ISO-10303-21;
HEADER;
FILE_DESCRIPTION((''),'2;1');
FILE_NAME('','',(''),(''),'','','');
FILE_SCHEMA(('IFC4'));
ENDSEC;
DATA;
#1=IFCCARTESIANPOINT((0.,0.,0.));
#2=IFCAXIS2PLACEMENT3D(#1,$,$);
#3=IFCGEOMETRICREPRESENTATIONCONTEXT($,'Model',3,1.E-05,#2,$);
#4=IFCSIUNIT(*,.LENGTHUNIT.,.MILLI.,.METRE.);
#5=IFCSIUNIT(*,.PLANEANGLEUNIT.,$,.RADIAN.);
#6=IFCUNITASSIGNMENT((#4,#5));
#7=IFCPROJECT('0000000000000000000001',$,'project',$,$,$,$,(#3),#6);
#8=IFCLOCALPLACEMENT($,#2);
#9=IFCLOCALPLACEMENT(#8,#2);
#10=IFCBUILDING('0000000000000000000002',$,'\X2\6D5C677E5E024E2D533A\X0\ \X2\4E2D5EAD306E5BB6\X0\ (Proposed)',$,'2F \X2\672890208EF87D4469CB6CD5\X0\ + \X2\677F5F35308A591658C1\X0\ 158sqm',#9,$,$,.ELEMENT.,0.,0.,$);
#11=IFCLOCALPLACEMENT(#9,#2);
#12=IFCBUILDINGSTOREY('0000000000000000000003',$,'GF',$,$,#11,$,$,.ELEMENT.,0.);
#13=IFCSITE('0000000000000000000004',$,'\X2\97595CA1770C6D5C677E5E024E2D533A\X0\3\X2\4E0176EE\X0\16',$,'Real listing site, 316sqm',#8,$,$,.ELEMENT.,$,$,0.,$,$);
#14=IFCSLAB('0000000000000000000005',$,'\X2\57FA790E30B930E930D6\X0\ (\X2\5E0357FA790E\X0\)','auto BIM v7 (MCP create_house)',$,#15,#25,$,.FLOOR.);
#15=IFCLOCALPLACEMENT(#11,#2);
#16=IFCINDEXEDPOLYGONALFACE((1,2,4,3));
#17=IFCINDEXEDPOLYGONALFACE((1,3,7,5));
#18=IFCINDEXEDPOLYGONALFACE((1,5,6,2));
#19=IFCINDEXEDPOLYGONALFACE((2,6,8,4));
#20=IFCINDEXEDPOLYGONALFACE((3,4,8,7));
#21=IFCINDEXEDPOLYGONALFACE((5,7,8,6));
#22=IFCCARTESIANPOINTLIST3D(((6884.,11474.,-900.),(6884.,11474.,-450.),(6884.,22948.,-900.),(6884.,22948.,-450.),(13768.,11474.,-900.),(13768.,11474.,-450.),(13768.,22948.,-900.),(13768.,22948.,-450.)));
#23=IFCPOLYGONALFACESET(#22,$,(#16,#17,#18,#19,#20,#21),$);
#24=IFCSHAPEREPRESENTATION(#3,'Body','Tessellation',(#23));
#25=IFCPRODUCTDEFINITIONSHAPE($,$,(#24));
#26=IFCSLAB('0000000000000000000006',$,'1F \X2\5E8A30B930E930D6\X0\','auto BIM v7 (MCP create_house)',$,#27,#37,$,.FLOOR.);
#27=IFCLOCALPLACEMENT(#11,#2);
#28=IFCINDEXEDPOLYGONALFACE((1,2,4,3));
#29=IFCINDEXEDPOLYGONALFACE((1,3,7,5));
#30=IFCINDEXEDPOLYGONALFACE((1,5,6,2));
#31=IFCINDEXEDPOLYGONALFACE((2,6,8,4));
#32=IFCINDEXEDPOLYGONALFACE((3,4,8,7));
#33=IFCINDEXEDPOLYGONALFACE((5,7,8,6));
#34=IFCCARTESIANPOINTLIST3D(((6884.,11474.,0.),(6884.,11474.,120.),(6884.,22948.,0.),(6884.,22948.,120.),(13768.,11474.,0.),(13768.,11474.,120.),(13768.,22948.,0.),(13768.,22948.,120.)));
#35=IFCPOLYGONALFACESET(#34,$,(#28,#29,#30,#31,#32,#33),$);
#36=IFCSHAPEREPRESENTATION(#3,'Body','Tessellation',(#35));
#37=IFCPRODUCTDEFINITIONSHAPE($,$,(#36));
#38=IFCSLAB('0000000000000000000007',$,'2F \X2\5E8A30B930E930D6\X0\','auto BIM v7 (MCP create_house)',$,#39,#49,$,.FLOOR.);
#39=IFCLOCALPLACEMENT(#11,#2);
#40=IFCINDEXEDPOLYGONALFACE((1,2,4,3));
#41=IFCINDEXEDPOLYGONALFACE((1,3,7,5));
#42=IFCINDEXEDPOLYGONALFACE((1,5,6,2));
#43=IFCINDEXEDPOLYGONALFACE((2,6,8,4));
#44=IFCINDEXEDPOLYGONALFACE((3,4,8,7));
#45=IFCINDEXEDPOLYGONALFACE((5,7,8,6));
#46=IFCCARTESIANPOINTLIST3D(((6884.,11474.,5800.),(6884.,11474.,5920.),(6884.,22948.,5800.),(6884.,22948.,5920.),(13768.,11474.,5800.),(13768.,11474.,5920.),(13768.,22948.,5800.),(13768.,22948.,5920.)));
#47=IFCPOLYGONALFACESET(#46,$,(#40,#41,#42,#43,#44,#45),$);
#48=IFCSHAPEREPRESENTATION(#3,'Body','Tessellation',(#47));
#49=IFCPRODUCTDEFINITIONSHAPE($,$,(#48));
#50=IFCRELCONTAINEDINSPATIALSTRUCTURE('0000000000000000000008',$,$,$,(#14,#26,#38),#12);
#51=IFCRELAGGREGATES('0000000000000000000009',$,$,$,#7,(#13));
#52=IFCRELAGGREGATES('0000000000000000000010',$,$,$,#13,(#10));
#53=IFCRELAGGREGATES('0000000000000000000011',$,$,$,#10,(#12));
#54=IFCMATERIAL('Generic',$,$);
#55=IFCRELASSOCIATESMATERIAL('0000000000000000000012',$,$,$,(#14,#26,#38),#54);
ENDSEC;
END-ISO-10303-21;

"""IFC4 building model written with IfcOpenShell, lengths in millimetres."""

from ifc_helpers import new_model, si_unit, frame, frame_2d, origin, place, context, project, spatial, rectangle, extrude, material, element, save


model = new_model("IFC4")

# Units and contexts
model_context = context("Model", 3, precision=1e-05, world=origin())
ifc_project = project(units=[si_unit("LENGTHUNIT", "METRE", prefix="MILLI"), si_unit("PLANEANGLEUNIT", "RADIAN")], contexts=[model_context])

# Site, building, storey
site_placement = place(None, origin())
site = spatial("IfcSite", under=ifc_project, at=site_placement, Name="静岡県浜松市中区3丁目16", ObjectType="Real listing site, 316sqm", CompositionType="ELEMENT", RefElevation=0.0)
building_placement = place(site_placement, origin())
building = spatial("IfcBuilding", under=site, at=building_placement, Name="浜松市中区 中庭の家 (Proposed)", ObjectType="2F 木造軸組構法 + 板張り外壁 158sqm", CompositionType="ELEMENT", ElevationOfRefHeight=0.0, ElevationOfTerrain=0.0)
storey_placement = place(building_placement, origin())
storey = spatial("IfcBuildingStorey", under=building, at=storey_placement, Name="GF", CompositionType="ELEMENT", Elevation=0.0)

# Slabs
ifc_material = material(Name="Generic")
slab_1_placement = place(storey_placement, frame((3442.0, 5737.0, -450.0)))
element("IfcSlab", 1, at=slab_1_placement, inside=storey, material=ifc_material, Name="基礎スラブ (布基礎)", Description="auto BIM v7 (MCP create_house)", PredefinedType="FLOOR", context=model_context, shape_type="SweptSolid", body=[
    extrude(rectangle(XDim=6884.0, YDim=11474.0, at=frame_2d((3442.0, 5737.0))), frame((3442.0, 5737.0, -450.0)), (0.0, 0.0, 1.0), 450.0),
])
slab_2_placement = place(storey_placement, frame((3442.0, 5737.0, 0.0)))
element("IfcSlab", 2, at=slab_2_placement, inside=storey, material=ifc_material, Name="1F 床スラブ", Description="auto BIM v7 (MCP create_house)", PredefinedType="FLOOR", context=model_context, shape_type="SweptSolid", body=[
    extrude(rectangle(XDim=6884.0, YDim=11474.0, at=frame_2d((3442.0, 5737.0))), frame((3442.0, 5737.0, 0.0)), (0.0, 0.0, 1.0), 120.0),
])
slab_3_placement = place(storey_placement, frame((3442.0, 5737.0, 2900.0)))
element("IfcSlab", 3, at=slab_3_placement, inside=storey, material=ifc_material, Name="2F 床スラブ", Description="auto BIM v7 (MCP create_house)", PredefinedType="FLOOR", context=model_context, shape_type="SweptSolid", body=[
    extrude(rectangle(XDim=6884.0, YDim=11474.0, at=frame_2d((3442.0, 5737.0))), frame((3442.0, 5737.0, 2900.0)), (0.0, 0.0, 1.0), 120.0),
])

save(model, "model.ifc")
